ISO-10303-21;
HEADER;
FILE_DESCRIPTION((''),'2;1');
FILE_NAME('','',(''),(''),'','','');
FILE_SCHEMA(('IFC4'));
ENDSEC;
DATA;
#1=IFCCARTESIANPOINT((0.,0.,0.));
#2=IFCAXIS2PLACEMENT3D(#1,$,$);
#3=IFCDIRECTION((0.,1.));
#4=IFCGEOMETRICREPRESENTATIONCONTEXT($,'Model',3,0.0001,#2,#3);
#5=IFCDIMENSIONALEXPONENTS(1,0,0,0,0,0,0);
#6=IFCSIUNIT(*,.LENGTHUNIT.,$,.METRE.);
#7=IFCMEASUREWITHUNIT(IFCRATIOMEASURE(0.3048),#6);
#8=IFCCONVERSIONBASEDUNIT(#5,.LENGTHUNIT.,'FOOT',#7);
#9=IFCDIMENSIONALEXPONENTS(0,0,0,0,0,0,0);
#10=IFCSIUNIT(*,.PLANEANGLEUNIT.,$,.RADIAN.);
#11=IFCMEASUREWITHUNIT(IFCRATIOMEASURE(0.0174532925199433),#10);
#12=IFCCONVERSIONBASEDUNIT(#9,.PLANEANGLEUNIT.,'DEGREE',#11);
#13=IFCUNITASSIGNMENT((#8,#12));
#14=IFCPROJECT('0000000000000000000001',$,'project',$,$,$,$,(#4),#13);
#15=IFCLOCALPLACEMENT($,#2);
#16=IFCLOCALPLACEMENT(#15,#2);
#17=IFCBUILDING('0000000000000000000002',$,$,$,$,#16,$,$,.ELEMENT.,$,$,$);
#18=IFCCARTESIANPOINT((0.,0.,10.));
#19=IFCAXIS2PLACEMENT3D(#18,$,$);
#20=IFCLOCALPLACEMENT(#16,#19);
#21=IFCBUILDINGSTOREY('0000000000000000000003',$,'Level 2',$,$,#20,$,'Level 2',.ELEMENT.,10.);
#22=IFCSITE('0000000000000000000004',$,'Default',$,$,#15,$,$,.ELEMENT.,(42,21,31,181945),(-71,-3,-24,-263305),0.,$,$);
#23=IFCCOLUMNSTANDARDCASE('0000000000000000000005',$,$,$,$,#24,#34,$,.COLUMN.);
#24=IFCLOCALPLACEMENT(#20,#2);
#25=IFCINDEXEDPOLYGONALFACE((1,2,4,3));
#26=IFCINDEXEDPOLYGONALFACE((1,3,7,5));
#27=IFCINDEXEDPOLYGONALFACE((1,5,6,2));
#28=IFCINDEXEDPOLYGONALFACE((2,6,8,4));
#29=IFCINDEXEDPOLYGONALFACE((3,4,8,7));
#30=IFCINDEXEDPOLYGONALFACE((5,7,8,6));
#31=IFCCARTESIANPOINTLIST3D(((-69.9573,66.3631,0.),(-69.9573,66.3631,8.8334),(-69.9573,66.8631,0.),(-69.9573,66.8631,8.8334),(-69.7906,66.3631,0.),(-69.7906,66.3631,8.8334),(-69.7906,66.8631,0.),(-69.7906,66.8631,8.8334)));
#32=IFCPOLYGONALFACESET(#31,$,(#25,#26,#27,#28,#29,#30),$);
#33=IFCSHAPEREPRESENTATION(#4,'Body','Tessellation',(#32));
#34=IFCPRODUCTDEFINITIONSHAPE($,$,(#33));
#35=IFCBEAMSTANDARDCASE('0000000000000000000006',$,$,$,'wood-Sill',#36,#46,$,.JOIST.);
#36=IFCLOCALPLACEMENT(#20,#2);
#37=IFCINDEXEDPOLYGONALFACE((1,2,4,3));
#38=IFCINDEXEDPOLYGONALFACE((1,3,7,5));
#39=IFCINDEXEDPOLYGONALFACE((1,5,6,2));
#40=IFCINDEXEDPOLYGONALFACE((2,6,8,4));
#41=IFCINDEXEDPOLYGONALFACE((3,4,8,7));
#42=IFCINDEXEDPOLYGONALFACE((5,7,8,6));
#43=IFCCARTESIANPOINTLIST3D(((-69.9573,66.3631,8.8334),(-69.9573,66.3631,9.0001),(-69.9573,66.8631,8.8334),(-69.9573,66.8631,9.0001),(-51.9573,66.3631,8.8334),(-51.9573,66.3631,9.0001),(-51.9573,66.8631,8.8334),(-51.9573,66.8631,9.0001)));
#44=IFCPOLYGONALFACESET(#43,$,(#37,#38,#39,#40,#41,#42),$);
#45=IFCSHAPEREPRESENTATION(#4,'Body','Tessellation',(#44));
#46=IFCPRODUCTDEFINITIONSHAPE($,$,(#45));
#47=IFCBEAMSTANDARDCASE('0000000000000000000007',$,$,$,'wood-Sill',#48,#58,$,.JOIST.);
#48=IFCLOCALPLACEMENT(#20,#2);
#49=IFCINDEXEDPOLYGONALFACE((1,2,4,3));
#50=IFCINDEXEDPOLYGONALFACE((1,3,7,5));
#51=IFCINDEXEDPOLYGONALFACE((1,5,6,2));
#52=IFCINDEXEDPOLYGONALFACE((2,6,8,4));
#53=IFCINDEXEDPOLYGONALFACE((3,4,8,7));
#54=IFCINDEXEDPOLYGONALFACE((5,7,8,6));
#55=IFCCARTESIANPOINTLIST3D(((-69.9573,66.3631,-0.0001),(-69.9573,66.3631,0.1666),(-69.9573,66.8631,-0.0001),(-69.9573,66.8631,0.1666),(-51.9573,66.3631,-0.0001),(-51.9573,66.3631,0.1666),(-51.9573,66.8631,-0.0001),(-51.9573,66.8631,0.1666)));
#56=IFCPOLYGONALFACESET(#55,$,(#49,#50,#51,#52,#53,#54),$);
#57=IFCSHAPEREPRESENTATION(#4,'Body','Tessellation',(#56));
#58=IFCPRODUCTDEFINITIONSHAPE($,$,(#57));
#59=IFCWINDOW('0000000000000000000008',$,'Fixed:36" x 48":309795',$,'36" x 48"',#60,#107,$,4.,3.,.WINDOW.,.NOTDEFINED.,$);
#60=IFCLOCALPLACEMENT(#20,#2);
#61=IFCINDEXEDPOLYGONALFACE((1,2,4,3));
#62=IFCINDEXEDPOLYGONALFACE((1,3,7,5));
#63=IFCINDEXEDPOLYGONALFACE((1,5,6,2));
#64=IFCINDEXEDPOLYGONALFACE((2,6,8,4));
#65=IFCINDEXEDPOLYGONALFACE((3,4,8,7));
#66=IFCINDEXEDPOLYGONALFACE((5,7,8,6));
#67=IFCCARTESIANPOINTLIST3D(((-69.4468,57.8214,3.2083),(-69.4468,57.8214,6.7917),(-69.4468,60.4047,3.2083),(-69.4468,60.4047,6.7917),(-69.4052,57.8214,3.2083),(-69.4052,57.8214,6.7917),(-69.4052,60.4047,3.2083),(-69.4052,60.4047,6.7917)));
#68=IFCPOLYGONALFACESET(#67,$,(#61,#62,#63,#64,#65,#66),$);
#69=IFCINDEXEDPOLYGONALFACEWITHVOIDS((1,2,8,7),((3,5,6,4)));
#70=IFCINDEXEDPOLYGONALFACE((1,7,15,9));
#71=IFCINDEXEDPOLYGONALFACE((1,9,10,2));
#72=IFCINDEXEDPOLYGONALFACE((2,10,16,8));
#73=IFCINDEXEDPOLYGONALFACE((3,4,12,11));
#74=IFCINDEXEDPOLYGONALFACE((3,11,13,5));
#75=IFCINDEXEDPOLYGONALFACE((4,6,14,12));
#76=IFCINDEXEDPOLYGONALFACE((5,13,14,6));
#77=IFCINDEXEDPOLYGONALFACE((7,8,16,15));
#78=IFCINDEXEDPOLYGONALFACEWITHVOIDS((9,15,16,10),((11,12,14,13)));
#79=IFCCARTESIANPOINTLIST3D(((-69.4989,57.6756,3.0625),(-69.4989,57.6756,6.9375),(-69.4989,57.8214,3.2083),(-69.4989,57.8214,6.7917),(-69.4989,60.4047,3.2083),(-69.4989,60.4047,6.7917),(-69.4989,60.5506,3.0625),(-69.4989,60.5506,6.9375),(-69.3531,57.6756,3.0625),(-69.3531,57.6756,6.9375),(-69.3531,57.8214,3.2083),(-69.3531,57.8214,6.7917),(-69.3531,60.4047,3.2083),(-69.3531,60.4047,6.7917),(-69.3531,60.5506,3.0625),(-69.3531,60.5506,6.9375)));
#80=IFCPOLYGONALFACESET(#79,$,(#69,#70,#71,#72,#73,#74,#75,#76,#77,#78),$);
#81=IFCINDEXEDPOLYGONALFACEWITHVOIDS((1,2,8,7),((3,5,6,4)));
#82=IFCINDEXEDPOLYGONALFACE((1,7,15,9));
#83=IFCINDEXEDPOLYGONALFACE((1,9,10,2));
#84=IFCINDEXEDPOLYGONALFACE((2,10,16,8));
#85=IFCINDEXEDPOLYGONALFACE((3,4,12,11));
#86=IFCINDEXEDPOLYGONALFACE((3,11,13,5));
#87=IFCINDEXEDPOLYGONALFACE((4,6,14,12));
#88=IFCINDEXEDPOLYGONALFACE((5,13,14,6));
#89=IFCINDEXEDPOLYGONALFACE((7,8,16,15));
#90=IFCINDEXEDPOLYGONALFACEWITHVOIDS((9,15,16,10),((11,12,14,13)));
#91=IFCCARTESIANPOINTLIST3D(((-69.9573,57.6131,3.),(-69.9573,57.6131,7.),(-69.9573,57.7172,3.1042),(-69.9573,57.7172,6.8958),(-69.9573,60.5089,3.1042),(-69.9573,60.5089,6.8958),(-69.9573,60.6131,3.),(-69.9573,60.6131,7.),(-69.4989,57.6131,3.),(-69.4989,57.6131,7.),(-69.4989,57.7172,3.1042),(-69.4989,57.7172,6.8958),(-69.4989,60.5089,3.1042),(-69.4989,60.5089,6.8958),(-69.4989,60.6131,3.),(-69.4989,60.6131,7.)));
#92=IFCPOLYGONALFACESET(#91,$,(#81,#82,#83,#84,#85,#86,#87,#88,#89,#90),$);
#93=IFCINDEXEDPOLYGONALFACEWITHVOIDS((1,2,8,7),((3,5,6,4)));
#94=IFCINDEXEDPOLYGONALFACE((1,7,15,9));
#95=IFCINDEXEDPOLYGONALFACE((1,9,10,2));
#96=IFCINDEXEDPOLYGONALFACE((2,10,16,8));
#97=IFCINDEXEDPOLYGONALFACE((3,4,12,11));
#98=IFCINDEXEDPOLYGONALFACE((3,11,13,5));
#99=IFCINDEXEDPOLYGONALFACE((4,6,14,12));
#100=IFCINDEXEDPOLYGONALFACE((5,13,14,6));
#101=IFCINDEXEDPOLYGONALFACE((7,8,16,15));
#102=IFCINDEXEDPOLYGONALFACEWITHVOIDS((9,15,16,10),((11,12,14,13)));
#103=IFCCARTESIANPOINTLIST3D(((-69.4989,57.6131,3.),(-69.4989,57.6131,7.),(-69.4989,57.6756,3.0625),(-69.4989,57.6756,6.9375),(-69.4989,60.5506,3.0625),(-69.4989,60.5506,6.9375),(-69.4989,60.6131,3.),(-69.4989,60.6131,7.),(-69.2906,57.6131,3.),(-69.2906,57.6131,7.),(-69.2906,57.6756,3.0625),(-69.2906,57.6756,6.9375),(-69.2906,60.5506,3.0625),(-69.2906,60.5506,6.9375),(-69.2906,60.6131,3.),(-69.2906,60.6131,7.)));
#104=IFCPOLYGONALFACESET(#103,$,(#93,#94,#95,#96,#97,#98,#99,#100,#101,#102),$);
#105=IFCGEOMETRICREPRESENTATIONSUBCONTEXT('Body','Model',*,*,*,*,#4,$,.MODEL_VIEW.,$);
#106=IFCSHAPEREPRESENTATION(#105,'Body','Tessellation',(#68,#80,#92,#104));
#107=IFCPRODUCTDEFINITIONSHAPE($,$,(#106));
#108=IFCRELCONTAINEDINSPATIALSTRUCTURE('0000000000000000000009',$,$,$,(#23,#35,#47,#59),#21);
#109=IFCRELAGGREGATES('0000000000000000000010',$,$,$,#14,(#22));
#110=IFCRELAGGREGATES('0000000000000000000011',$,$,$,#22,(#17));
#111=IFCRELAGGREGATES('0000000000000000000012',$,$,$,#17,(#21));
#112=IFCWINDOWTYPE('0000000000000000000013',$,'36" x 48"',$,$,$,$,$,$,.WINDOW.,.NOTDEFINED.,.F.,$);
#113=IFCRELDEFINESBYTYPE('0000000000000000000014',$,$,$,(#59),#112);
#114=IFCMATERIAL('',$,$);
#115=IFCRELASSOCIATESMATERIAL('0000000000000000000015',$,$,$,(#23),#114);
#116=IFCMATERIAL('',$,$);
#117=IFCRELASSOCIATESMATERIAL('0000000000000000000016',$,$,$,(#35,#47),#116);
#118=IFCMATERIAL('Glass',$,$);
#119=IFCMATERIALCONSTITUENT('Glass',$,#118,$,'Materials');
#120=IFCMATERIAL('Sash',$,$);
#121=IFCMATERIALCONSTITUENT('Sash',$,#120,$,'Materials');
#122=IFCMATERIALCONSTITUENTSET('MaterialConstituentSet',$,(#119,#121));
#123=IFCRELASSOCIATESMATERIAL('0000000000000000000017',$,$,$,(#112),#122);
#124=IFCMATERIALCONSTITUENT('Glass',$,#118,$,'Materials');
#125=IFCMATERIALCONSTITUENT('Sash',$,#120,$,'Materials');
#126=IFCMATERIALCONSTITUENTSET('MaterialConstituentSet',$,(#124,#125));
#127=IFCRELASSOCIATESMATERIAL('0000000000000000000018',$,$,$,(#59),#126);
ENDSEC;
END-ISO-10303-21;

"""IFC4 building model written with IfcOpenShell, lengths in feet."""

from ifc_helpers import new_model, entity, si_unit, converted_unit, direction, frame, frame_2d, origin, origin_with_axes, place, context, subcontext, project, spatial, polyline, rectangle, outline, extrude, source, transform, mapped, material, constituent, constituent_set, type_object, type_shapes, element, save


model = new_model("IFC4")

# Units and contexts
model_context = context("Model", 3, precision=0.0001, world=origin(), true_north=direction((0.0, 1.0)))
body_context = subcontext(model_context, "Body", "Model", "MODEL_VIEW")
ifc_project = project(units=[converted_unit("LENGTHUNIT", "FOOT", entity("IfcRatioMeasure", 0.3048), si_unit("LENGTHUNIT", "METRE"), dimensions=[1, 0, 0, 0, 0, 0, 0]), converted_unit("PLANEANGLEUNIT", "DEGREE", entity("IfcRatioMeasure", 0.0174532925199433), si_unit("PLANEANGLEUNIT", "RADIAN"), dimensions=[0, 0, 0, 0, 0, 0, 0])], contexts=[model_context])

# Site, building, storey
site_placement = place(None, origin())
site = spatial("IfcSite", under=ifc_project, at=site_placement, Name="Default", CompositionType="ELEMENT", RefLatitude=(42, 21, 31, 181945), RefLongitude=(-71, -3, -24, -263305), RefElevation=0.0)
building_placement = place(site_placement, origin())
building = spatial("IfcBuilding", under=site, at=building_placement, CompositionType="ELEMENT")
storey_placement = place(building_placement, frame((0.0, 0.0, 10.0)))
storey = spatial("IfcBuildingStorey", under=building, at=storey_placement, Name="Level 2", LongName="Level 2", CompositionType="ELEMENT", Elevation=10.0)

# Column
ifc_material_1 = material(Name="")
placement_1 = place(storey_placement, frame((-69.9573, 66.6131, 0.0)))
for number, where, z_axis, x_axis in (
    (1, (0.0833, 0.0, 0.0), (0.0, 0.0, 1.0), (1.0, 0.0, 0.0)),
):
    element("IfcColumnStandardCase", number, at=place(placement_1, frame(where, z_axis=z_axis, x_axis=x_axis)), inside=storey, material=ifc_material_1, PredefinedType="COLUMN", context=model_context, shape_type="SweptSolid", body=[
        extrude(rectangle(XDim=0.1667, YDim=0.5), origin(), (0.0, 0.0, 1.0), 8.8334),
    ])
placement_2 = place(storey_placement, frame((-69.6239, 19.7797, 0.0), z_axis=(0.0, 0.0, 1.0), x_axis=(0.0, 1.0, 0.0)))

# Beams
ifc_material_2 = material(Name="")
for number, where, z_axis, x_axis in (
    (2, (0.0, 0.0, 8.9167), (1.0, 0.0, 0.0), (0.0, 0.0, 1.0)),
    (3, (0.0, 0.0, 0.0833), (1.0, 0.0, 0.0), (0.0, 0.0, 1.0)),
):
    element("IfcBeamStandardCase", number, at=place(placement_1, frame(where, z_axis=z_axis, x_axis=x_axis)), inside=storey, material=ifc_material_2, ObjectType="wood-Sill", PredefinedType="JOIST", context=model_context, shape_type="SweptSolid", body=[
        extrude(rectangle(XDim=0.1667, YDim=0.5), origin_with_axes(), (0.0, 0.0, 1.0), 18.0),
    ])

# Window
ifc_material_3 = material(Name="Glass")
ifc_constituent_1 = constituent(ifc_material_3, Name="Glass", Category="Materials")
ifc_material_4 = material(Name="Sash")
ifc_constituent_2 = constituent(ifc_material_4, Name="Sash", Category="Materials")
ifc_constituent_set_1 = constituent_set(constituents=[ifc_constituent_1, ifc_constituent_2], Name="MaterialConstituentSet")
ifc_constituent_3 = constituent(ifc_material_3, Name="Glass", Category="Materials")
ifc_constituent_4 = constituent(ifc_material_4, Name="Sash", Category="Materials")
ifc_constituent_set_2 = constituent_set(constituents=[ifc_constituent_3, ifc_constituent_4], Name="MaterialConstituentSet")
window_type = type_object("IfcWindowType", Name="36\" x 48\"", ParameterTakesPrecedence=False, PartitioningType="NOTDEFINED", PredefinedType="WINDOW", material=ifc_constituent_set_2)
shared_shape = source(origin(), body_context, "Body", "SweptSolid", [
    extrude(rectangle(XDim=0.0417, YDim=2.5833, at=frame_2d((0.0, 0.0), x_axis=(1.0, 0.0))), frame((1.5, 0.5312, 0.2083), z_axis=(0.0, 0.0, 1.0), x_axis=(0.0, 1.0, 0.0)), (0.0, 0.0, 1.0), 3.5833),
    extrude(outline(polyline([(-1.4375, -1.9375), (1.4375, -1.9375), (1.4375, 1.9375), (-1.4375, 1.9375), (-1.4375, -1.9375)]), holes=[polyline([(-1.2917, -1.7917), (-1.2917, 1.7917), (1.2917, 1.7917), (1.2917, -1.7917), (-1.2917, -1.7917)])]), frame((1.5, 0.4583, 2.0), z_axis=(0.0, 1.0, 0.0), x_axis=(1.0, 0.0, 0.0)), (0.0, 0.0, 1.0), 0.1458),
    extrude(outline(polyline([(-1.5, -2.0), (1.5, -2.0), (1.5, 2.0), (-1.5, 2.0), (-1.5, -2.0)]), holes=[polyline([(-1.3958, -1.8958), (-1.3958, 1.8958), (1.3958, 1.8958), (1.3958, -1.8958), (-1.3958, -1.8958)])]), frame((1.5, 0.0, 2.0), z_axis=(0.0, 1.0, 0.0), x_axis=(1.0, 0.0, 0.0)), (0.0, 0.0, 1.0), 0.4583),
    extrude(outline(polyline([(-2.0, -1.5), (2.0, -1.5), (2.0, 1.5), (-2.0, 1.5), (-2.0, -1.5)]), holes=[polyline([(-1.9375, -1.4375), (-1.9375, 1.4375), (1.9375, 1.4375), (1.9375, -1.4375), (-1.9375, -1.4375)])]), frame((1.5, 0.4583, 2.0), z_axis=(0.0, 1.0, 0.0), x_axis=(0.0, 0.0, -1.0)), (0.0, 0.0, 1.0), 0.2083),
])
type_shapes(window_type, [shared_shape])
placement_3 = place(placement_2, frame((40.8333, 0.3333, 3.0)))
window_placement = place(placement_3, frame((0.0, 0.0, 0.0), z_axis=(0.0, 0.0, 1.0), x_axis=(-1.0, 0.0, 0.0)))
element("IfcWindow", 4, at=window_placement, inside=storey, type_object=window_type, material=ifc_constituent_set_1, Name="Fixed:36\" x 48\":309795", ObjectType="36\" x 48\"", OverallHeight=4.0, OverallWidth=3.0, PartitioningType="NOTDEFINED", PredefinedType="WINDOW", context=body_context, shape_type="MappedRepresentation", body=[
    mapped(shared_shape, transform((0.0, 0.0, 0.0), scale=1.0)),
])

save(model, "model.ifc")
